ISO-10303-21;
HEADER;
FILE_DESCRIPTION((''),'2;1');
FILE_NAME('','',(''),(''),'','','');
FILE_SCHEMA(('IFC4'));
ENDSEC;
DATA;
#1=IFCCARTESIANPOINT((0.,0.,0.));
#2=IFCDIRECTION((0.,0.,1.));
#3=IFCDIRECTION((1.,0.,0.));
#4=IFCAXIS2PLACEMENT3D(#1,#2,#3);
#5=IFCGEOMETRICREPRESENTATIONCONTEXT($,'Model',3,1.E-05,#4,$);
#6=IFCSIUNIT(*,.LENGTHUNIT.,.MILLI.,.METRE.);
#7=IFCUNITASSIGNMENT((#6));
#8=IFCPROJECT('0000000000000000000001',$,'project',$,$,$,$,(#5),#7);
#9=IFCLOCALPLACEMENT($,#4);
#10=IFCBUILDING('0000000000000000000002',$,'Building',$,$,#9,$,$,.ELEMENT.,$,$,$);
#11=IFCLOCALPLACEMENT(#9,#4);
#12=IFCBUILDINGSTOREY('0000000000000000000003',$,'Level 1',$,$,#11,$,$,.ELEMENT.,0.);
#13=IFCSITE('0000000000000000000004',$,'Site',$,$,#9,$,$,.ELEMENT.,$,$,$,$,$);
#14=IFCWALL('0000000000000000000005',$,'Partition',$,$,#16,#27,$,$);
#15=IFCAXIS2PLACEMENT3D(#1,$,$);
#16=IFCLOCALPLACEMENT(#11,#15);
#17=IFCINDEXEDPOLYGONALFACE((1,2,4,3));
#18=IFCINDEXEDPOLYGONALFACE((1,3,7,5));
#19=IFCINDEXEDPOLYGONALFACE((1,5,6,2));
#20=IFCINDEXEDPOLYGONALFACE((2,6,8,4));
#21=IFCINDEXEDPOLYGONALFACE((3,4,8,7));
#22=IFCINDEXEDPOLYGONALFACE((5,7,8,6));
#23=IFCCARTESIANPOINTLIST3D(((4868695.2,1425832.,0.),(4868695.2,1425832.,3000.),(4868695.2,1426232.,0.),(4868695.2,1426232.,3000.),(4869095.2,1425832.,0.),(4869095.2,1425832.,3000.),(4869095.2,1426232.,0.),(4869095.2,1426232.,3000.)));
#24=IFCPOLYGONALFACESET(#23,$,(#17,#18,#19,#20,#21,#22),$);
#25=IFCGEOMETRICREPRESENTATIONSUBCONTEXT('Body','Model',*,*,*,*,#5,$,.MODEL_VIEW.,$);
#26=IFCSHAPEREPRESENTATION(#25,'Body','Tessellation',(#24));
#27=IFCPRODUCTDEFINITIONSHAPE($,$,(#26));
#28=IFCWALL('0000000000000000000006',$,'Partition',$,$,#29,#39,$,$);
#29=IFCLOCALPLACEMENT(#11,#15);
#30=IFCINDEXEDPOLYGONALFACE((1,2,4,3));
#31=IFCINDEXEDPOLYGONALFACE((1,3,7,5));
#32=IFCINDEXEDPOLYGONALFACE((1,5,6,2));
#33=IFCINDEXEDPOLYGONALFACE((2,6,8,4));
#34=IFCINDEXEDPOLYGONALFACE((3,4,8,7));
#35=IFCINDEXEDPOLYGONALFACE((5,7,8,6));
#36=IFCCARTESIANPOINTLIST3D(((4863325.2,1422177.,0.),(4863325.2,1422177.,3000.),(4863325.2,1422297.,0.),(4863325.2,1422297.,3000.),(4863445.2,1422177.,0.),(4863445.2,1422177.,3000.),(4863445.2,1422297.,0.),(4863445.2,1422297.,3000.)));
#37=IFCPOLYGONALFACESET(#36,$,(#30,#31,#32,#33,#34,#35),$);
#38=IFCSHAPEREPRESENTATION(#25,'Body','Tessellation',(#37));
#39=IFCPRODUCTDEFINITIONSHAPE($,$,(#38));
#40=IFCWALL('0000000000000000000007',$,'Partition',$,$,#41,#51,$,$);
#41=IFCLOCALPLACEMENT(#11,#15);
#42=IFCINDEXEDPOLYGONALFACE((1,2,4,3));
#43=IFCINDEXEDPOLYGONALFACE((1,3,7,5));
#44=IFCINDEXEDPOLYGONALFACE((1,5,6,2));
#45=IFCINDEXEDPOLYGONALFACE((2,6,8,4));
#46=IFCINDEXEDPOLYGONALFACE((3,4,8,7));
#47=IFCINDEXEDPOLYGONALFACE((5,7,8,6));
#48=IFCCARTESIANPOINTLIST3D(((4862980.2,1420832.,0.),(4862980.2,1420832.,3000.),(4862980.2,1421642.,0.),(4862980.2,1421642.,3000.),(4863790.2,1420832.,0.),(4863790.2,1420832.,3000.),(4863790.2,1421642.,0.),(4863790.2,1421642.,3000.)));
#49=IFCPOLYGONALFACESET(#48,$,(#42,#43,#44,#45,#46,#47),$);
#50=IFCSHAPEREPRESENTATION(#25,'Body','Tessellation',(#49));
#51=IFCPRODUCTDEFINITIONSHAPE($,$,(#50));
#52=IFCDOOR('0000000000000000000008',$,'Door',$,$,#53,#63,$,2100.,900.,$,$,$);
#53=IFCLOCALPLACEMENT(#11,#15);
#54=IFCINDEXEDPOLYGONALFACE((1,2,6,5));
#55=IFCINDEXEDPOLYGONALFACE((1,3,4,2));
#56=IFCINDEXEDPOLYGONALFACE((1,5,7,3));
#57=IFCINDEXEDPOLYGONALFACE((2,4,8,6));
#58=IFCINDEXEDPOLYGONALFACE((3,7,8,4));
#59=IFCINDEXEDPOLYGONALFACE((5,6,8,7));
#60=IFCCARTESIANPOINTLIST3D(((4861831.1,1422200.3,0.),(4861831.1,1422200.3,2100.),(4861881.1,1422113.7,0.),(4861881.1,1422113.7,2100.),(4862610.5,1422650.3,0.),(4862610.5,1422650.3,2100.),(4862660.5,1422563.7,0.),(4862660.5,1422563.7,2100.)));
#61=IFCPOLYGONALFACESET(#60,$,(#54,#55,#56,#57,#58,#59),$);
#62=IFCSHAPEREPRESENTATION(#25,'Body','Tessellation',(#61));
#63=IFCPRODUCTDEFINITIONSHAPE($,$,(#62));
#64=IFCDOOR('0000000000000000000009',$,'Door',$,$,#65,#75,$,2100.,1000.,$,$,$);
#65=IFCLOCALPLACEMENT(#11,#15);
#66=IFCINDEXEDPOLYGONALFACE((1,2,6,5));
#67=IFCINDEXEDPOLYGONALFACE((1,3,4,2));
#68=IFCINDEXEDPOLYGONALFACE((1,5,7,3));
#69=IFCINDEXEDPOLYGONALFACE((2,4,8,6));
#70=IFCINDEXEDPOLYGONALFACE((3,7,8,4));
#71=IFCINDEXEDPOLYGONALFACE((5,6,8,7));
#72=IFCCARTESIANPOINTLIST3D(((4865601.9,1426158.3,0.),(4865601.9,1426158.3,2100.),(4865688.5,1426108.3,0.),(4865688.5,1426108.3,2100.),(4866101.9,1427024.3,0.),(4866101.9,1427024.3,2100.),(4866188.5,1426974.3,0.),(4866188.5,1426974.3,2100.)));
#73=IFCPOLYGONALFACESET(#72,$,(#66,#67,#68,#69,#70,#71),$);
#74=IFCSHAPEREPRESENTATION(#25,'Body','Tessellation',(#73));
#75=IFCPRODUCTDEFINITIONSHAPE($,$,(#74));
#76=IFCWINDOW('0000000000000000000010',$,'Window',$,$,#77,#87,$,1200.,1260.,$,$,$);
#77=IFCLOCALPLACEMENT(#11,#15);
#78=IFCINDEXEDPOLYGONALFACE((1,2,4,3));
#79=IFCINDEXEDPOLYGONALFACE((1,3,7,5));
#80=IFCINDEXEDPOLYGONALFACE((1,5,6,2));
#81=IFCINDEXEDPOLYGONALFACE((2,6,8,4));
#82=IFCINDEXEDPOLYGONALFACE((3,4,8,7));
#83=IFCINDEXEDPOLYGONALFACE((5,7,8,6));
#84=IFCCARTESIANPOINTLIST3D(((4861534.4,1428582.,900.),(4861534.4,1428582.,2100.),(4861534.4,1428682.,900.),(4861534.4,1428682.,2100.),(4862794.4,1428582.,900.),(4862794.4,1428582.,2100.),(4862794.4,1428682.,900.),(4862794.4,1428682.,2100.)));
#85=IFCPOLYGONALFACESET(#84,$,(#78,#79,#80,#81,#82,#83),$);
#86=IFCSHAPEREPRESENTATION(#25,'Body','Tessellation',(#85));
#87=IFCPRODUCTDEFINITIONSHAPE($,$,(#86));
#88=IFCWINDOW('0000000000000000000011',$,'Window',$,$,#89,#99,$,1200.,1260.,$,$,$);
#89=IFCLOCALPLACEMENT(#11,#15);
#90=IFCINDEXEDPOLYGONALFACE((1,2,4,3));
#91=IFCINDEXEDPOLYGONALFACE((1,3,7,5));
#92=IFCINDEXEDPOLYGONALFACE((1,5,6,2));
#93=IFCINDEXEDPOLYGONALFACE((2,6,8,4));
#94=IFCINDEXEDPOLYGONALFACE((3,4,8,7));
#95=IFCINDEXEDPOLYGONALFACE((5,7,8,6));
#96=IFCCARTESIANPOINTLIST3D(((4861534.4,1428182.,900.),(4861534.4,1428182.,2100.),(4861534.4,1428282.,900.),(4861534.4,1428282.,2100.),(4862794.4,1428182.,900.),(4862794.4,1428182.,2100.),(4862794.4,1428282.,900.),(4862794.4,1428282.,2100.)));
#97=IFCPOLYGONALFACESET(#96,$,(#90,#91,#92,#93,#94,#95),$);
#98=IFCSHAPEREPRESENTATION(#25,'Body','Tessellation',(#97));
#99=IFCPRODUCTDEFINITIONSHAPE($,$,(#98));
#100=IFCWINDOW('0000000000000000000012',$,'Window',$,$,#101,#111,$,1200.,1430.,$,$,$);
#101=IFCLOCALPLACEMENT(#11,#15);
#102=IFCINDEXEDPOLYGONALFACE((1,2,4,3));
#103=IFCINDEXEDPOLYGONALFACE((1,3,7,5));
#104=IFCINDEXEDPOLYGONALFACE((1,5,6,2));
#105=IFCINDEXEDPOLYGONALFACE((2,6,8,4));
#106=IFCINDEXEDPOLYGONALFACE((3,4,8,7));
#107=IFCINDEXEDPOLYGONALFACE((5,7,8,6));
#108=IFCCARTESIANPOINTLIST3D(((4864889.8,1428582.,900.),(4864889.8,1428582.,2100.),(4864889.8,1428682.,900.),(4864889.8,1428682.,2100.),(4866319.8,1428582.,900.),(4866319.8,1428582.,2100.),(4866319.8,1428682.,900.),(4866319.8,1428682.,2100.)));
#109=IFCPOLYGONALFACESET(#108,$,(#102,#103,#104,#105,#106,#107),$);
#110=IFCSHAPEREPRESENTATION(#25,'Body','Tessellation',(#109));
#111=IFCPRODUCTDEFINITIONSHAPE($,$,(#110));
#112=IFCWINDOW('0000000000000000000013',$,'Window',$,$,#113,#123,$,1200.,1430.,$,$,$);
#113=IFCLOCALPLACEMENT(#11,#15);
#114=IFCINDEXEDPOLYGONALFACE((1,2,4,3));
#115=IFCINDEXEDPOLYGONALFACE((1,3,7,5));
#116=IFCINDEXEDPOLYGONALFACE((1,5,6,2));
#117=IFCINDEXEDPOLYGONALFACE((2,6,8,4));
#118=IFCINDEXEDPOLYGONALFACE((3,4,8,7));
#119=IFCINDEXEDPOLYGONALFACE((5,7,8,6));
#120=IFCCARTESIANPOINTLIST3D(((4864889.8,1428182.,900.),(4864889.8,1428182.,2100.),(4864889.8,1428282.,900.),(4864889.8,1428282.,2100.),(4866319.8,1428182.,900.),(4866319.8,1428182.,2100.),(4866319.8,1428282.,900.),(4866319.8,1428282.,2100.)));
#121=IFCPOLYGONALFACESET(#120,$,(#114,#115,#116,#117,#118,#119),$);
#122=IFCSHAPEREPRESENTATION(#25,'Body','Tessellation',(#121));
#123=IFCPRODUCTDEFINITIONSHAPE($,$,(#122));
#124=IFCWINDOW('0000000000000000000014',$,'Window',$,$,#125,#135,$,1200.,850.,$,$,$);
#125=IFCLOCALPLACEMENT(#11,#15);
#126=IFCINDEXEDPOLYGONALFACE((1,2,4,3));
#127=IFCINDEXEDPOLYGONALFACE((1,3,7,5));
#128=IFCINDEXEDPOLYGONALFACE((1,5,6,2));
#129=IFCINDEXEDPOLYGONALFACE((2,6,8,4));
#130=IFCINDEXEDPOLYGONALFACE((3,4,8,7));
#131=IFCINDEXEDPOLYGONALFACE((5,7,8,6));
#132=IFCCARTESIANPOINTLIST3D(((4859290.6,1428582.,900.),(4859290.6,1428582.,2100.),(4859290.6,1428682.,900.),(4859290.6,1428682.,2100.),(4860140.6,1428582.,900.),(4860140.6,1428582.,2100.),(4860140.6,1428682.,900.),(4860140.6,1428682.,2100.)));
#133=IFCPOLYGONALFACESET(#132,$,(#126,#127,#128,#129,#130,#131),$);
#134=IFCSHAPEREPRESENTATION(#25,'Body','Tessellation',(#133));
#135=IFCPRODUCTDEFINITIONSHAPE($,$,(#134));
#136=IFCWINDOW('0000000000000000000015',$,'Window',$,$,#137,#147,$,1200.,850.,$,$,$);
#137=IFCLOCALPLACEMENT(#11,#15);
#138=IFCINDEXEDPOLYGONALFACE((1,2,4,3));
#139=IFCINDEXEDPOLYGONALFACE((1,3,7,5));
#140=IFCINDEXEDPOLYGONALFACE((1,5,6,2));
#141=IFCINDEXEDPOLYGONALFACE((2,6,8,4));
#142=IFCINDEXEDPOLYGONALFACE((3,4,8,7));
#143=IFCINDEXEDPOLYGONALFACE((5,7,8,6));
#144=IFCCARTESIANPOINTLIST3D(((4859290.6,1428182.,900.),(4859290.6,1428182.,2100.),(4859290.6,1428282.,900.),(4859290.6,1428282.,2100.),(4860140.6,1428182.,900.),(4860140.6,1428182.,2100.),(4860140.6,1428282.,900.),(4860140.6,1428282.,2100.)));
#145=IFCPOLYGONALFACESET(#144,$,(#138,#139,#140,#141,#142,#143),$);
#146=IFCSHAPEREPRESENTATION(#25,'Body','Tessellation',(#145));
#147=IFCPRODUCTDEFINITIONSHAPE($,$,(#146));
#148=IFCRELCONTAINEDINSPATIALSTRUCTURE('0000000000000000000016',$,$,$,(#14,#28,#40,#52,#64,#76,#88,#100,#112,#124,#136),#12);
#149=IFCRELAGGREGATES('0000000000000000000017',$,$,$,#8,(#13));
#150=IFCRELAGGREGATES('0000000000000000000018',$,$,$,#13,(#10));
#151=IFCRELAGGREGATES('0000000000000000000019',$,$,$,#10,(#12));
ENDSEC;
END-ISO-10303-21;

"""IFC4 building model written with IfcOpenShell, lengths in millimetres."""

from ifc_helpers import new_model, si_unit, frame, frame_2d, origin_with_axes, place, context, subcontext, project, spatial, rectangle, extrude, element, save


model = new_model("IFC4")

# Units and contexts
model_context = context("Model", 3, precision=1e-05, world=origin_with_axes())
body_context = subcontext(model_context, "Body", "Model", "MODEL_VIEW")
ifc_project = project(units=[si_unit("LENGTHUNIT", "METRE", prefix="MILLI")], contexts=[model_context])

# Site, building, storey
placement = place(None, origin_with_axes())
site = spatial("IfcSite", under=ifc_project, at=placement, Name="Site", CompositionType="ELEMENT")
building = spatial("IfcBuilding", under=site, at=placement, Name="Building", CompositionType="ELEMENT")
storey_placement = place(placement, origin_with_axes())
storey = spatial("IfcBuildingStorey", under=building, at=storey_placement, Name="Level 1", CompositionType="ELEMENT", Elevation=0.0)

# Walls
wall_1_placement = place(placement, frame((4868895.2, 1426232.0, 0.0), z_axis=(0.0, 0.0, 1.0), x_axis=(0.0, -1.0, 0.0)))
element("IfcWall", 1, at=wall_1_placement, inside=storey, Name="Partition", context=body_context, shape_type="SweptSolid", body=[
    extrude(rectangle(XDim=400.0, YDim=400.0, at=frame_2d((200.0, 0.0), x_axis=(1.0, 0.0))), origin_with_axes(), (0.0, 0.0, 1.0), 3000.0),
])
wall_2_placement = place(placement, frame((4863325.2, 1422237.0, 0.0), z_axis=(0.0, 0.0, 1.0), x_axis=(1.0, 0.0, 0.0)))
element("IfcWall", 2, at=wall_2_placement, inside=storey, Name="Partition", context=body_context, shape_type="SweptSolid", body=[
    extrude(rectangle(XDim=120.0, YDim=120.0, at=frame_2d((60.0, 0.0), x_axis=(1.0, 0.0))), origin_with_axes(), (0.0, 0.0, 1.0), 3000.0),
])
wall_3_placement = place(placement, frame((4863385.2, 1421642.0, 0.0), z_axis=(0.0, 0.0, 1.0), x_axis=(0.0, -1.0, 0.0)))
element("IfcWall", 3, at=wall_3_placement, inside=storey, Name="Partition", context=body_context, shape_type="SweptSolid", body=[
    extrude(rectangle(XDim=810.0, YDim=810.0, at=frame_2d((405.0, 0.0), x_axis=(1.0, 0.0))), origin_with_axes(), (0.0, 0.0, 1.0), 3000.0),
])

# Doors
door_1_placement = place(placement, frame((4862635.5, 1422607.0, 0.0), z_axis=(0.0, 0.0, 1.0), x_axis=(-0.866025, -0.5, 0.0)))
element("IfcDoor", 4, at=door_1_placement, inside=storey, Name="Door", OverallHeight=2100.0, OverallWidth=900.0, context=body_context, shape_type="SweptSolid", body=[
    extrude(rectangle(XDim=900.0, YDim=100.0, at=frame_2d((450.0, 0.0), x_axis=(1.0, 0.0))), origin_with_axes(), (0.0, 0.0, 1.0), 2100.0),
])
door_2_placement = place(placement, frame((4866145.2, 1426999.3, 0.0), z_axis=(0.0, 0.0, 1.0), x_axis=(-0.5, -0.866025, 0.0)))
element("IfcDoor", 5, at=door_2_placement, inside=storey, Name="Door", OverallHeight=2100.0, OverallWidth=1000.0, context=body_context, shape_type="SweptSolid", body=[
    extrude(rectangle(XDim=1000.0, YDim=100.0, at=frame_2d((500.0, 0.0), x_axis=(1.0, 0.0))), origin_with_axes(), (0.0, 0.0, 1.0), 2100.0),
])

# Windows
for number, where, z_axis, x_axis, name in (
    (6, (4861534.4, 1428632.0, 900.0), (0.0, 0.0, 1.0), (1.0, 0.0, 0.0), "Window"),
    (7, (4861534.4, 1428232.0, 900.0), (0.0, 0.0, 1.0), (1.0, 0.0, 0.0), "Window"),
):
    element("IfcWindow", number, at=place(placement, frame(where, z_axis=z_axis, x_axis=x_axis)), inside=storey, Name=name, OverallHeight=1200.0, OverallWidth=1260.0, context=body_context, shape_type="SweptSolid", body=[
        extrude(rectangle(XDim=1260.0, YDim=100.0, at=frame_2d((630.0, 0.0), x_axis=(1.0, 0.0))), origin_with_axes(), (0.0, 0.0, 1.0), 1200.0),
    ])
for number, where, z_axis, x_axis, name in (
    (8, (4864889.8, 1428632.0, 900.0), (0.0, 0.0, 1.0), (1.0, 0.0, 0.0), "Window"),
    (9, (4864889.8, 1428232.0, 900.0), (0.0, 0.0, 1.0), (1.0, 0.0, 0.0), "Window"),
):
    element("IfcWindow", number, at=place(placement, frame(where, z_axis=z_axis, x_axis=x_axis)), inside=storey, Name=name, OverallHeight=1200.0, OverallWidth=1430.0, context=body_context, shape_type="SweptSolid", body=[
        extrude(rectangle(XDim=1430.0, YDim=100.0, at=frame_2d((715.0, 0.0), x_axis=(1.0, 0.0))), origin_with_axes(), (0.0, 0.0, 1.0), 1200.0),
    ])
for number, where, z_axis, x_axis, name in (
    (10, (4859290.6, 1428632.0, 900.0), (0.0, 0.0, 1.0), (1.0, 0.0, 0.0), "Window"),
    (11, (4859290.6, 1428232.0, 900.0), (0.0, 0.0, 1.0), (1.0, 0.0, 0.0), "Window"),
):
    element("IfcWindow", number, at=place(placement, frame(where, z_axis=z_axis, x_axis=x_axis)), inside=storey, Name=name, OverallHeight=1200.0, OverallWidth=850.0, context=body_context, shape_type="SweptSolid", body=[
        extrude(rectangle(XDim=850.0, YDim=100.0, at=frame_2d((425.0, 0.0), x_axis=(1.0, 0.0))), origin_with_axes(), (0.0, 0.0, 1.0), 1200.0),
    ])

save(model, "model.ifc")
